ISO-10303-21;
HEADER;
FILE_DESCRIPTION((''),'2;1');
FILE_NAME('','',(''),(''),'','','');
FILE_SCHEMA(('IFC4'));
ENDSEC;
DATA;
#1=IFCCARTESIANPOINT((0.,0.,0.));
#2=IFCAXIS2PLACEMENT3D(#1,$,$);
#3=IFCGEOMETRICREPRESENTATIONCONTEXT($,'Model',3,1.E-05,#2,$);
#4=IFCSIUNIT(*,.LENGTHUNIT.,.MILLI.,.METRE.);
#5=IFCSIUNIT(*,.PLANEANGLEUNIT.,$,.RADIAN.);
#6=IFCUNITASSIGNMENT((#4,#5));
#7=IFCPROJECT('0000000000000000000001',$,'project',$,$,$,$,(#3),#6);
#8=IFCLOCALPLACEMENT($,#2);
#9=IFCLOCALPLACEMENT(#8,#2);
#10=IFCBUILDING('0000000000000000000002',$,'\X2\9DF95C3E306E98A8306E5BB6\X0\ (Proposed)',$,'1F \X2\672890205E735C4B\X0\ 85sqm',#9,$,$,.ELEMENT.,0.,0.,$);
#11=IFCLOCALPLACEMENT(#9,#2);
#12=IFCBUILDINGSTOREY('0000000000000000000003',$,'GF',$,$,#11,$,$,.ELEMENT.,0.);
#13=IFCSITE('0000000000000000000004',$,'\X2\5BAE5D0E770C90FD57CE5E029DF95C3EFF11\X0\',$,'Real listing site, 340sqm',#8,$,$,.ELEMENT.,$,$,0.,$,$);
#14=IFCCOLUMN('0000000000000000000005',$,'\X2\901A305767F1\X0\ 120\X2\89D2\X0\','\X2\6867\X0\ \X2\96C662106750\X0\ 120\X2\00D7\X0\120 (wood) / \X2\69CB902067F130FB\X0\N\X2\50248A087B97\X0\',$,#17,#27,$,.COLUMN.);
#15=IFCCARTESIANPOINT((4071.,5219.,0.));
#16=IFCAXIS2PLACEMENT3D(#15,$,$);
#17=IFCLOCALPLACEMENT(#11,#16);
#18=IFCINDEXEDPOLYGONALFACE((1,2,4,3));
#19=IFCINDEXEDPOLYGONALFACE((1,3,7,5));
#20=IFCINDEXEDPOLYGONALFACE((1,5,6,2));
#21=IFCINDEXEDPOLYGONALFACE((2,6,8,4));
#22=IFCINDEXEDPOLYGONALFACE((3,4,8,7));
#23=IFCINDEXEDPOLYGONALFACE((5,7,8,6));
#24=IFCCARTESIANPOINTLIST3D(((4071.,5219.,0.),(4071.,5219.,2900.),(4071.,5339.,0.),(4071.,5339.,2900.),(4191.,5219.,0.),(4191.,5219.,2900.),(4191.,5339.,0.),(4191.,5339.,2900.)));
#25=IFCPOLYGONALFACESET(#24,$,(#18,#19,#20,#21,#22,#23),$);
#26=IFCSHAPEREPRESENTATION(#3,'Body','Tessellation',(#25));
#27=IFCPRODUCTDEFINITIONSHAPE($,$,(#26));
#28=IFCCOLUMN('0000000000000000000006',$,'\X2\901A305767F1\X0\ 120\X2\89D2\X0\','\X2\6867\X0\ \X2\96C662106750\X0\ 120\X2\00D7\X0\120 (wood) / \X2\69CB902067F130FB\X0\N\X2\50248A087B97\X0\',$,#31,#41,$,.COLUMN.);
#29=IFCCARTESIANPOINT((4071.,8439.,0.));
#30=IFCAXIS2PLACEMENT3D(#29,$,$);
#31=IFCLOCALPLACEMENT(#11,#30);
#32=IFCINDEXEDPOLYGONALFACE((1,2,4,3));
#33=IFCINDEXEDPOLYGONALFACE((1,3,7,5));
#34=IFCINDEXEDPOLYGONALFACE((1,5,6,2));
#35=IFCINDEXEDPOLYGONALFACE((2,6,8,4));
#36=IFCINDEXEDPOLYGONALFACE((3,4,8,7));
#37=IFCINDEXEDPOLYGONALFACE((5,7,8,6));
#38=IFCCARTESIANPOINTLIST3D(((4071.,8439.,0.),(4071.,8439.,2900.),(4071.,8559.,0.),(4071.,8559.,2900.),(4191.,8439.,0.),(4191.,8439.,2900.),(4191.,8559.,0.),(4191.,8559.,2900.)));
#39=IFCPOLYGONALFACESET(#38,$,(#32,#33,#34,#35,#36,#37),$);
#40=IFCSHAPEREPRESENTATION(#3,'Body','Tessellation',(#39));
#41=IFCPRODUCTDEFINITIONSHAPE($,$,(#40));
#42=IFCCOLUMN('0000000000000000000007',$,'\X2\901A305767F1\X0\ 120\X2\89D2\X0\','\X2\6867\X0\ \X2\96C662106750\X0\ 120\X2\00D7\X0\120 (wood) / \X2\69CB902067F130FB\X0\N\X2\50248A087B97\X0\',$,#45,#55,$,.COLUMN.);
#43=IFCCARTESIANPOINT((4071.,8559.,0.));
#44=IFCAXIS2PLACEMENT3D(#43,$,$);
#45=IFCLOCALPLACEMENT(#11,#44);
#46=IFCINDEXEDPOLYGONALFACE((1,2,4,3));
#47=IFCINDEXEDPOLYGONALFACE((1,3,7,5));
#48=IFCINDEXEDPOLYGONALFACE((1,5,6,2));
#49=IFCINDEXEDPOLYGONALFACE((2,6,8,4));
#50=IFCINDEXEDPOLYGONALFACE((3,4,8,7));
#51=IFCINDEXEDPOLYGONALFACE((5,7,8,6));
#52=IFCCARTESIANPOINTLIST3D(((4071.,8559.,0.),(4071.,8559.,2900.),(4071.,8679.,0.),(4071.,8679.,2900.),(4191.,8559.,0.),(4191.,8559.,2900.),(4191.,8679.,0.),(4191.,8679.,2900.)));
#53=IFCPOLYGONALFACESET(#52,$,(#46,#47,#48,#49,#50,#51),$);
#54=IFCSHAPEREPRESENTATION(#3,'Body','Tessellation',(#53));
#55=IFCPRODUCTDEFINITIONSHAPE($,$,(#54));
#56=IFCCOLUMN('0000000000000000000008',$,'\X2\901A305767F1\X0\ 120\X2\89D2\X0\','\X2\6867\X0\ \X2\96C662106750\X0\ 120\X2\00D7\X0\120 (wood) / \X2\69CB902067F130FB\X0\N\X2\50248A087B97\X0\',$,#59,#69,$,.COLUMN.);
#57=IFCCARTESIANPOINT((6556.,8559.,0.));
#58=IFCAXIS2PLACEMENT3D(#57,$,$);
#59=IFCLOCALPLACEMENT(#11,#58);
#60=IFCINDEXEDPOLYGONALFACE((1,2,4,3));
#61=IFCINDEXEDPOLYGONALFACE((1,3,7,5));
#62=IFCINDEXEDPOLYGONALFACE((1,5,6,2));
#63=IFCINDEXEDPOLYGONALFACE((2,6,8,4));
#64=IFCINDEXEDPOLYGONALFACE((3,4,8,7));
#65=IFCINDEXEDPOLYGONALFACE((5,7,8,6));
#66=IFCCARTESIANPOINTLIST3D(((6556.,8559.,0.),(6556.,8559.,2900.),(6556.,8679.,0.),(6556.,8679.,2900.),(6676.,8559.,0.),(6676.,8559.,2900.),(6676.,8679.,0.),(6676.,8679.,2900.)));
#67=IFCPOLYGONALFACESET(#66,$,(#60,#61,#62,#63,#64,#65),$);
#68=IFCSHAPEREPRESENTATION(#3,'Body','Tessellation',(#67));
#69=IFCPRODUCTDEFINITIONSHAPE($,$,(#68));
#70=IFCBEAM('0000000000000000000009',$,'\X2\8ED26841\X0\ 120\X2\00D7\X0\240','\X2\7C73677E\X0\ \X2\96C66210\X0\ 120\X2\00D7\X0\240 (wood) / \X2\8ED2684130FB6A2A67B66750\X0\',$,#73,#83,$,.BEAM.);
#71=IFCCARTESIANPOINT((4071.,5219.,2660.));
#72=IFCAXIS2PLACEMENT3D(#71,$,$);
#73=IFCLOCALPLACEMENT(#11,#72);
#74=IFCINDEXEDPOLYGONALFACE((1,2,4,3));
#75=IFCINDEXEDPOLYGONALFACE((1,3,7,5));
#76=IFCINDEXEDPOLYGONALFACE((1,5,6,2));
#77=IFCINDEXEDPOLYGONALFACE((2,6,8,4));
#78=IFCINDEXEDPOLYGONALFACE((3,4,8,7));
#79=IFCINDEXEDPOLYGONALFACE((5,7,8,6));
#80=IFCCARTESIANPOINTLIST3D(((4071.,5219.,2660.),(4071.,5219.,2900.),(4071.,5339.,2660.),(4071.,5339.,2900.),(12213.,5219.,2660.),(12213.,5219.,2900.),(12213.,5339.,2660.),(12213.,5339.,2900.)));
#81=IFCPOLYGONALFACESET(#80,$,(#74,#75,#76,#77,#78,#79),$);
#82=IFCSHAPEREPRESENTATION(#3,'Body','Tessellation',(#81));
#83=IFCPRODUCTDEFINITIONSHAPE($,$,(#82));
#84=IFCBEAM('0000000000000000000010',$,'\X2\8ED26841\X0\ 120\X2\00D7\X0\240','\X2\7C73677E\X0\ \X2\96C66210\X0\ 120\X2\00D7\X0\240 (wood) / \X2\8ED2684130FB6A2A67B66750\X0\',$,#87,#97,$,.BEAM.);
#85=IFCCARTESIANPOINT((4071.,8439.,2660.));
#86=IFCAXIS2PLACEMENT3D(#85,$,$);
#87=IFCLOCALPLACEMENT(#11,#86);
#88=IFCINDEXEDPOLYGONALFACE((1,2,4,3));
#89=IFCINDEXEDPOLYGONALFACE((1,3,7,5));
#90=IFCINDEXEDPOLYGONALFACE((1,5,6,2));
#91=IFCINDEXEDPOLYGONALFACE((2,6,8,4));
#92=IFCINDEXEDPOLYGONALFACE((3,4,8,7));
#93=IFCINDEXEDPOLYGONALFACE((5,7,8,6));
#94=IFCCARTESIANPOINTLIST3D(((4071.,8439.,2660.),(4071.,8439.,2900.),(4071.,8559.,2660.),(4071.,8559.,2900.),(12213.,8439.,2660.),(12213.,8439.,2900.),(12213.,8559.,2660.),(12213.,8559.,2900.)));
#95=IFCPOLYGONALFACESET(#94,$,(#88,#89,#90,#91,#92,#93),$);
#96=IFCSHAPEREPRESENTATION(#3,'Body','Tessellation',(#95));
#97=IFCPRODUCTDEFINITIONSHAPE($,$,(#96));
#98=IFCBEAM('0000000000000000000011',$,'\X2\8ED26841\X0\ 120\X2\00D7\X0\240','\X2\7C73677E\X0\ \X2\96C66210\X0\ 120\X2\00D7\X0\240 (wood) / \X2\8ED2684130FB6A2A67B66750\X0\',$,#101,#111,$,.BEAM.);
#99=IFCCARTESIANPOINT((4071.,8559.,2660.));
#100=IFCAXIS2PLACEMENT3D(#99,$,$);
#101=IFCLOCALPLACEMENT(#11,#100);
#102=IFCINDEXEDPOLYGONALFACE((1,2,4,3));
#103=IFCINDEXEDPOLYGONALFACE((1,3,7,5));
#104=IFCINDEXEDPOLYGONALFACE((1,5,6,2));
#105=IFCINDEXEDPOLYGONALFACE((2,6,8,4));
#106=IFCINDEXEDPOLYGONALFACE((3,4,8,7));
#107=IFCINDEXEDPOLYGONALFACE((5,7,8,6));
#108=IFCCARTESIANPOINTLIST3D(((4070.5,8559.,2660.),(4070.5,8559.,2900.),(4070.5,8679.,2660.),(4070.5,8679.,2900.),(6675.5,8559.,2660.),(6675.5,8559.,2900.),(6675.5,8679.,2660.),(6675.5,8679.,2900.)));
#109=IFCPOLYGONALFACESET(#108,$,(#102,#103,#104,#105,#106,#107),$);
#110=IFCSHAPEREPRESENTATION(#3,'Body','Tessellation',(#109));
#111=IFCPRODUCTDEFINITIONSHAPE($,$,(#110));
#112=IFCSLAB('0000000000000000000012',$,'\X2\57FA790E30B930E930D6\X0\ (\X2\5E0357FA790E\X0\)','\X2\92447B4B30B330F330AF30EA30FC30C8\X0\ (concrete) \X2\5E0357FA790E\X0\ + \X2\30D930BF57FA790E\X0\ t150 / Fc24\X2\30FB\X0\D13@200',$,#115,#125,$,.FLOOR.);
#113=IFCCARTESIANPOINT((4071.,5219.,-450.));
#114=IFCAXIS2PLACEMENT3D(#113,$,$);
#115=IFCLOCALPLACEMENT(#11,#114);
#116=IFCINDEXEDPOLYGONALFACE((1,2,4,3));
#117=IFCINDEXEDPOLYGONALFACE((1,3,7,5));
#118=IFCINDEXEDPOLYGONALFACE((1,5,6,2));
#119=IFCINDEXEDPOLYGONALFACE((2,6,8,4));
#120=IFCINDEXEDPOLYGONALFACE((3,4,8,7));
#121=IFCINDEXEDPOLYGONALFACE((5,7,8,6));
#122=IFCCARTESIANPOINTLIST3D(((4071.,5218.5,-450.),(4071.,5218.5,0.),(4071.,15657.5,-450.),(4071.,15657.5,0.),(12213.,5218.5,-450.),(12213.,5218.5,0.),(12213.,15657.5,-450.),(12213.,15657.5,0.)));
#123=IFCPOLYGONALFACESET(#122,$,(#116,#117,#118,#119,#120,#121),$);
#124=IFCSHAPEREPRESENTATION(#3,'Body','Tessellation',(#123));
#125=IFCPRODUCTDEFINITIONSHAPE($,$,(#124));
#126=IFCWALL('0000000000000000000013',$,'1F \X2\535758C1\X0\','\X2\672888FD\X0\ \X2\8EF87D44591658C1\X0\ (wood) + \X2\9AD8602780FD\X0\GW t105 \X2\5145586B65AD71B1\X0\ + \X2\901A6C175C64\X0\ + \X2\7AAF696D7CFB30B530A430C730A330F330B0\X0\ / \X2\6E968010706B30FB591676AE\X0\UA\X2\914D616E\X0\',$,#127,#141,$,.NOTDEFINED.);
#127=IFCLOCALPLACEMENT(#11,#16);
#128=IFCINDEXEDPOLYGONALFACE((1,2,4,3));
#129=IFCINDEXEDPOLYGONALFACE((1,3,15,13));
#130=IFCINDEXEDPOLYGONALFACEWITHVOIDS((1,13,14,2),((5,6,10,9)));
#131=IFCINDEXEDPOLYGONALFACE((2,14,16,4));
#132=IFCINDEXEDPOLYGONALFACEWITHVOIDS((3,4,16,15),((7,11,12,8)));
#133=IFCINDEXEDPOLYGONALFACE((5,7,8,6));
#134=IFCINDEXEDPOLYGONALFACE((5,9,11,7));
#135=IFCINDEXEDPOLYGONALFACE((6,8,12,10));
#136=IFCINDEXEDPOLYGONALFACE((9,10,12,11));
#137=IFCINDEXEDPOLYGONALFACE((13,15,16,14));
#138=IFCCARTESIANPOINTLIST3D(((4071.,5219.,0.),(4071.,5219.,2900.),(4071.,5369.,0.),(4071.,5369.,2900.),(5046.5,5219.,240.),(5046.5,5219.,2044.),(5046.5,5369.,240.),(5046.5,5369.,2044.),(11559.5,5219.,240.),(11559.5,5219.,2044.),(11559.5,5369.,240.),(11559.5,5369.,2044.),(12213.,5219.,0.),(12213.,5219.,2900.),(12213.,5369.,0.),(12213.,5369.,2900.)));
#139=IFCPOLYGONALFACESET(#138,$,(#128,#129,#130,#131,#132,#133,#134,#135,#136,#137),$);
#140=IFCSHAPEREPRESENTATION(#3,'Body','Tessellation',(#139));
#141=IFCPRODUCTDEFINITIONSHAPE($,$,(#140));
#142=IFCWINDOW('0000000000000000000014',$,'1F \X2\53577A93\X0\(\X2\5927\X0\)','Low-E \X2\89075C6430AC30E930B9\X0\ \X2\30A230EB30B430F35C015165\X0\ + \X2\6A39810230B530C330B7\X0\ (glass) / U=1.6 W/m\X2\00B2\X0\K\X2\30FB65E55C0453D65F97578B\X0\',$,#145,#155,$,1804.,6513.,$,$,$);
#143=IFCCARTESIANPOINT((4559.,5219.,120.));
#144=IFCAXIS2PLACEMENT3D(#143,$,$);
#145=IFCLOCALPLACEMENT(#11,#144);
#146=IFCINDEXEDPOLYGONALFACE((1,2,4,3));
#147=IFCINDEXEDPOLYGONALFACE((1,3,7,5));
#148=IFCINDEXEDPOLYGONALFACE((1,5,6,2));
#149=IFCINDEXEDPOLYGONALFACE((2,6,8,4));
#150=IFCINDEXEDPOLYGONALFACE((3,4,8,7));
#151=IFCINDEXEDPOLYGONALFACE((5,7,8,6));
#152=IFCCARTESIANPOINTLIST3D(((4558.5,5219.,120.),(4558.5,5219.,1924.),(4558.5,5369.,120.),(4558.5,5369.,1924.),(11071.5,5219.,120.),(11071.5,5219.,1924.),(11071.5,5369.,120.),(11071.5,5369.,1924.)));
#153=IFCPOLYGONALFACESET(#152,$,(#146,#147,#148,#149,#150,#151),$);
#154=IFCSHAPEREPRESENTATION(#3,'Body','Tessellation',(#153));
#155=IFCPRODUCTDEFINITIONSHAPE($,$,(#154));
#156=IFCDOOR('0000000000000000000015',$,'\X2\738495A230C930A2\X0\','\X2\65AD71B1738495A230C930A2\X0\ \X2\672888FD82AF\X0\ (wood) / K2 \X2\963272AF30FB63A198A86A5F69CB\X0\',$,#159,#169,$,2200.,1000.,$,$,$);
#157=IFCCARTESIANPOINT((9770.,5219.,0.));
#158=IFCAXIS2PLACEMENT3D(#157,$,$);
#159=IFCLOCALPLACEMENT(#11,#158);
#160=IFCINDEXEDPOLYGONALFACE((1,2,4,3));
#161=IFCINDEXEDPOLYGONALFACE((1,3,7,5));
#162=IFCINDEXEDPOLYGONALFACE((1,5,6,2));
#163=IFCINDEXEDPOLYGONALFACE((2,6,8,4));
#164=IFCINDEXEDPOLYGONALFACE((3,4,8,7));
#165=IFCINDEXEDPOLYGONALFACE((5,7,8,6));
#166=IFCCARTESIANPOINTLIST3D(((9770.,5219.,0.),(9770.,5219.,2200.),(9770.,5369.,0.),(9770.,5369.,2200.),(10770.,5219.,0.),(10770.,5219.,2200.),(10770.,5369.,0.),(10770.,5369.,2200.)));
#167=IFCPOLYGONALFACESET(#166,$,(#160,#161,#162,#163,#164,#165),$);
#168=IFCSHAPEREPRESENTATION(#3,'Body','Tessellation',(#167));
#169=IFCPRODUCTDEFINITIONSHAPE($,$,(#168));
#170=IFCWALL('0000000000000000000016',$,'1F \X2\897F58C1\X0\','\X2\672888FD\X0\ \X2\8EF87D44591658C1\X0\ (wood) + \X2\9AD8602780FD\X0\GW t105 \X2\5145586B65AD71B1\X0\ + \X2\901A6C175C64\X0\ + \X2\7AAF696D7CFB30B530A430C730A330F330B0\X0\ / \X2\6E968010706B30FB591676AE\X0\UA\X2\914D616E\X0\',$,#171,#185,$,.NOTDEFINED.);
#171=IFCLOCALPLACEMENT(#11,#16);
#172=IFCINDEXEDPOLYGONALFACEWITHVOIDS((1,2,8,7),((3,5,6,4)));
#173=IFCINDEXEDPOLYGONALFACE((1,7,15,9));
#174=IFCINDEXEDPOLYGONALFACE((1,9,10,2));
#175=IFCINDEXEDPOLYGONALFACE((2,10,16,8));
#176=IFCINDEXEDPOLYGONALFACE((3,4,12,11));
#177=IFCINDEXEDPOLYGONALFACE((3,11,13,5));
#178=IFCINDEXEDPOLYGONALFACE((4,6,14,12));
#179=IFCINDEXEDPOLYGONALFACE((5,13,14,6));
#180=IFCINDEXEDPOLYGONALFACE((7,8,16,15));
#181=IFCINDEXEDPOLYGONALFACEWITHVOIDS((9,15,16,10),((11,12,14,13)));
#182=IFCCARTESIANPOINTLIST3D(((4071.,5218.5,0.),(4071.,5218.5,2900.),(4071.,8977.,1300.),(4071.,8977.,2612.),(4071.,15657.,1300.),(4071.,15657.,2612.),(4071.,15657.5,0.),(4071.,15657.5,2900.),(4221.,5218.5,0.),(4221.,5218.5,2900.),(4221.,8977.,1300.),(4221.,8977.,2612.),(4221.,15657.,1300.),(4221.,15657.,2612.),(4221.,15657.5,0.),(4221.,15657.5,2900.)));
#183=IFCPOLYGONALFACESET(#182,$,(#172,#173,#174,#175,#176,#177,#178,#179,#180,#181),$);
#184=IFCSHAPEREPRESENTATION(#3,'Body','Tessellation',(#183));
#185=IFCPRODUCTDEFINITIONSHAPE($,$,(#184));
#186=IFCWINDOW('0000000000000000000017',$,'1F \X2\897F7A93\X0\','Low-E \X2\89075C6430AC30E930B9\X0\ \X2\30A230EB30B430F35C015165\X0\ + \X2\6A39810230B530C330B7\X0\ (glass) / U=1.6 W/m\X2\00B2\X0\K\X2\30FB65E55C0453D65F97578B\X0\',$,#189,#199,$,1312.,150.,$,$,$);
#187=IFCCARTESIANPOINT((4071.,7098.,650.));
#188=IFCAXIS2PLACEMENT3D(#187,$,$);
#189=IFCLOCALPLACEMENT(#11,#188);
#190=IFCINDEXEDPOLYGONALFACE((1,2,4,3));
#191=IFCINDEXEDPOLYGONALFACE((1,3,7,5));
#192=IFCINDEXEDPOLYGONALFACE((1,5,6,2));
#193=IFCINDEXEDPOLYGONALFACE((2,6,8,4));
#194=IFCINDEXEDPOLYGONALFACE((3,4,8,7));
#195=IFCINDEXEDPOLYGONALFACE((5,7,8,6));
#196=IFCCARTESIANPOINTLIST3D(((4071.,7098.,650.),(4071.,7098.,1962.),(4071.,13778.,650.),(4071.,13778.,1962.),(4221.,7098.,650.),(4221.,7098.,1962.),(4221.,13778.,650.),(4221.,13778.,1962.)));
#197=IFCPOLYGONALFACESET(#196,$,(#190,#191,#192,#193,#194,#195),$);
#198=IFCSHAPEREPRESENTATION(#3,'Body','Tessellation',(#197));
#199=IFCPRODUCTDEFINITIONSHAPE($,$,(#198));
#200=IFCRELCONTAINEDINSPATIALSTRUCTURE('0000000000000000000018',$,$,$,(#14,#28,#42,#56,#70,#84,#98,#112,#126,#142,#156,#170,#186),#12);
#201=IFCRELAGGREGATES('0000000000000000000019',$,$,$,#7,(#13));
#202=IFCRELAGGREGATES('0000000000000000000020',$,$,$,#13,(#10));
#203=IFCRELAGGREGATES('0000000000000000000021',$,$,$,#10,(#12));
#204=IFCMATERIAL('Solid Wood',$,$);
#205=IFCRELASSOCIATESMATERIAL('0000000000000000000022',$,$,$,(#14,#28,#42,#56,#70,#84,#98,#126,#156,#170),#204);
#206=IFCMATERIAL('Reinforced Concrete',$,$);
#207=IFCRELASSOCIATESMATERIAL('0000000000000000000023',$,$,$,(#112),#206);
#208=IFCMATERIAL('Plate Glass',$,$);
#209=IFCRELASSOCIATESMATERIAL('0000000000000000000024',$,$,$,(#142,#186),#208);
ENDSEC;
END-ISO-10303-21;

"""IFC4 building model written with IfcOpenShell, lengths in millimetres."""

from ifc_helpers import new_model, si_unit, frame, frame_2d, origin, place, context, project, spatial, rectangle, extrude, material, element, fill, save


model = new_model("IFC4")

# Units and contexts
model_context = context("Model", 3, precision=1e-05, world=origin())
ifc_project = project(units=[si_unit("LENGTHUNIT", "METRE", prefix="MILLI"), si_unit("PLANEANGLEUNIT", "RADIAN")], contexts=[model_context])

# Site, building, storey
site_placement = place(None, origin())
site = spatial("IfcSite", under=ifc_project, at=site_placement, Name="宮崎県都城市鷹尾１", ObjectType="Real listing site, 340sqm", CompositionType="ELEMENT", RefElevation=0.0)
building_placement = place(site_placement, origin())
building = spatial("IfcBuilding", under=site, at=building_placement, Name="鷹尾の風の家 (Proposed)", ObjectType="1F 木造平屋 85sqm", CompositionType="ELEMENT", ElevationOfRefHeight=0.0, ElevationOfTerrain=0.0)
storey_placement = place(building_placement, origin())
storey = spatial("IfcBuildingStorey", under=building, at=storey_placement, Name="GF", CompositionType="ELEMENT", Elevation=0.0)

# Columns
ifc_material_1 = material(Name="Solid Wood")
column_1_placement = place(storey_placement, frame((4071.0, 5219.0, 0.0)))
element("IfcColumn", 1, at=column_1_placement, inside=storey, material=ifc_material_1, Name="通し柱 120角", Description="桧 集成材 120×120 (wood) / 構造柱・N値計算", PredefinedType="COLUMN", context=model_context, shape_type="SweptSolid", body=[
    extrude(rectangle(XDim=120.0, YDim=120.0, at=frame_2d((60.0, 60.0))), frame((4071.0, 5219.0, 0.0)), (0.0, 0.0, 1.0), 2900.0),
])
column_2_placement = place(storey_placement, frame((4071.0, 8439.0, 0.0)))
element("IfcColumn", 2, at=column_2_placement, inside=storey, material=ifc_material_1, Name="通し柱 120角", Description="桧 集成材 120×120 (wood) / 構造柱・N値計算", PredefinedType="COLUMN", context=model_context, shape_type="SweptSolid", body=[
    extrude(rectangle(XDim=120.0, YDim=120.0, at=frame_2d((60.0, 60.0))), frame((4071.0, 8439.0, 0.0)), (0.0, 0.0, 1.0), 2900.0),
])
column_3_placement = place(storey_placement, frame((4071.0, 8559.0, 0.0)))
element("IfcColumn", 3, at=column_3_placement, inside=storey, material=ifc_material_1, Name="通し柱 120角", Description="桧 集成材 120×120 (wood) / 構造柱・N値計算", PredefinedType="COLUMN", context=model_context, shape_type="SweptSolid", body=[
    extrude(rectangle(XDim=120.0, YDim=120.0, at=frame_2d((60.0, 60.0))), frame((4071.0, 8559.0, 0.0)), (0.0, 0.0, 1.0), 2900.0),
])
column_4_placement = place(storey_placement, frame((6556.0, 8559.0, 0.0)))
element("IfcColumn", 4, at=column_4_placement, inside=storey, material=ifc_material_1, Name="通し柱 120角", Description="桧 集成材 120×120 (wood) / 構造柱・N値計算", PredefinedType="COLUMN", context=model_context, shape_type="SweptSolid", body=[
    extrude(rectangle(XDim=120.0, YDim=120.0, at=frame_2d((60.0, 60.0))), frame((6556.0, 8559.0, 0.0)), (0.0, 0.0, 1.0), 2900.0),
])

# Beams
beam_1_placement = place(storey_placement, frame((4071.0, 5219.0, 2660.0)))
element("IfcBeam", 5, at=beam_1_placement, inside=storey, material=ifc_material_1, Name="軒桁 120×240", Description="米松 集成 120×240 (wood) / 軒桁・横架材", PredefinedType="BEAM", context=model_context, shape_type="SweptSolid", body=[
    extrude(rectangle(XDim=8142.0, YDim=120.0, at=frame_2d((4071.0, 60.0))), frame((4071.0, 5219.0, 2660.0)), (0.0, 0.0, 1.0), 240.0),
])
beam_2_placement = place(storey_placement, frame((4071.0, 8439.0, 2660.0)))
element("IfcBeam", 6, at=beam_2_placement, inside=storey, material=ifc_material_1, Name="軒桁 120×240", Description="米松 集成 120×240 (wood) / 軒桁・横架材", PredefinedType="BEAM", context=model_context, shape_type="SweptSolid", body=[
    extrude(rectangle(XDim=8142.0, YDim=120.0, at=frame_2d((4071.0, 60.0))), frame((4071.0, 8439.0, 2660.0)), (0.0, 0.0, 1.0), 240.0),
])
beam_3_placement = place(storey_placement, frame((4071.0, 8559.0, 2660.0)))
element("IfcBeam", 7, at=beam_3_placement, inside=storey, material=ifc_material_1, Name="軒桁 120×240", Description="米松 集成 120×240 (wood) / 軒桁・横架材", PredefinedType="BEAM", context=model_context, shape_type="SweptSolid", body=[
    extrude(rectangle(XDim=2605.0, YDim=120.0, at=frame_2d((1302.0, 60.0))), frame((4071.0, 8559.0, 2660.0)), (0.0, 0.0, 1.0), 240.0),
])

# Slab
ifc_material_2 = material(Name="Reinforced Concrete")
slab_1_placement = place(storey_placement, frame((4071.0, 5219.0, -450.0)))
element("IfcSlab", 8, at=slab_1_placement, inside=storey, material=ifc_material_2, Name="基礎スラブ (布基礎)", Description="鉄筋コンクリート (concrete) 布基礎 + ベタ基礎 t150 / Fc24・D13@200", PredefinedType="FLOOR", context=model_context, shape_type="SweptSolid", body=[
    extrude(rectangle(XDim=8142.0, YDim=10439.0, at=frame_2d((4071.0, 5219.0))), frame((4071.0, 5219.0, -450.0)), (0.0, 0.0, 1.0), 450.0),
])

# Wall, openings, window, door
wall_1_placement = place(storey_placement, frame((4071.0, 5219.0, 0.0)))
wall_1 = element("IfcWall", 9, at=wall_1_placement, inside=storey, material=ifc_material_1, Name="1F 南壁", Description="木製 軸組外壁 (wood) + 高性能GW t105 充填断熱 + 通気層 + 窯業系サイディング / 準耐火・外皮UA配慮", PredefinedType="NOTDEFINED", context=model_context, shape_type="SweptSolid", body=[
    extrude(rectangle(XDim=8142.0, YDim=150.0, at=frame_2d((4071.0, 75.0))), frame((4071.0, 5219.0, 0.0)), (0.0, 0.0, 1.0), 2900.0),
])
opening_1_placement = place(storey_placement, frame((4559.0, 5219.0, 120.0)))
opening_1 = element("IfcOpeningElement", 10, at=opening_1_placement, cuts=wall_1, PredefinedType="NOTDEFINED", context=model_context, shape_type="SweptSolid", body=[
    extrude(rectangle(XDim=6513.0, YDim=150.0, at=frame_2d((3256.0, 75.0))), frame((4559.0, 5219.0, 120.0)), (0.0, 0.0, 1.0), 1804.0),
])
opening_2_placement = place(storey_placement, frame((9770.0, 5219.0, 0.0)))
opening_2 = element("IfcOpeningElement", 11, at=opening_2_placement, cuts=wall_1, PredefinedType="NOTDEFINED", context=model_context, shape_type="SweptSolid", body=[
    extrude(rectangle(XDim=1000.0, YDim=150.0, at=frame_2d((500.0, 75.0))), frame((9770.0, 5219.0, 0.0)), (0.0, 0.0, 1.0), 2200.0),
])
ifc_material_3 = material(Name="Plate Glass")
window_1_placement = place(storey_placement, frame((4559.0, 5219.0, 120.0)))
window_1 = element("IfcWindow", 12, at=window_1_placement, inside=storey, material=ifc_material_3, Name="1F 南窓(大)", Description="Low-E 複層ガラス アルゴン封入 + 樹脂サッシ (glass) / U=1.6 W/m²K・日射取得型", OverallHeight=1804.0, OverallWidth=6513.0, context=model_context, shape_type="SweptSolid", body=[
    extrude(rectangle(XDim=6513.0, YDim=150.0, at=frame_2d((3256.0, 75.0))), frame((4559.0, 5219.0, 120.0)), (0.0, 0.0, 1.0), 1804.0),
])
fill(opening_1, window_1)
door_placement = place(storey_placement, frame((9770.0, 5219.0, 0.0)))
door = element("IfcDoor", 13, at=door_placement, inside=storey, material=ifc_material_1, Name="玄関ドア", Description="断熱玄関ドア 木製芯 (wood) / K2 防犯・採風機構", OverallHeight=2200.0, OverallWidth=1000.0, context=model_context, shape_type="SweptSolid", body=[
    extrude(rectangle(XDim=1000.0, YDim=150.0, at=frame_2d((500.0, 75.0))), frame((9770.0, 5219.0, 0.0)), (0.0, 0.0, 1.0), 2200.0),
])
fill(opening_2, door)

# Wall, opening, window
wall_2_placement = place(storey_placement, frame((4071.0, 5219.0, 0.0)))
wall_2 = element("IfcWall", 14, at=wall_2_placement, inside=storey, material=ifc_material_1, Name="1F 西壁", Description="木製 軸組外壁 (wood) + 高性能GW t105 充填断熱 + 通気層 + 窯業系サイディング / 準耐火・外皮UA配慮", PredefinedType="NOTDEFINED", context=model_context, shape_type="SweptSolid", body=[
    extrude(rectangle(XDim=150.0, YDim=10439.0, at=frame_2d((75.0, 5219.0))), frame((4071.0, 5219.0, 0.0)), (0.0, 0.0, 1.0), 2900.0),
])
opening_3_placement = place(storey_placement, frame((4071.0, 7098.0, 650.0)))
opening_3 = element("IfcOpeningElement", 15, at=opening_3_placement, cuts=wall_2, PredefinedType="NOTDEFINED", context=model_context, shape_type="SweptSolid", body=[
    extrude(rectangle(XDim=150.0, YDim=6680.0, at=frame_2d((75.0, 3340.0))), frame((4071.0, 7098.0, 650.0)), (0.0, 0.0, 1.0), 1312.0),
])
window_2_placement = place(storey_placement, frame((4071.0, 7098.0, 650.0)))
window_2 = element("IfcWindow", 16, at=window_2_placement, inside=storey, material=ifc_material_3, Name="1F 西窓", Description="Low-E 複層ガラス アルゴン封入 + 樹脂サッシ (glass) / U=1.6 W/m²K・日射取得型", OverallHeight=1312.0, OverallWidth=150.0, context=model_context, shape_type="SweptSolid", body=[
    extrude(rectangle(XDim=150.0, YDim=6680.0, at=frame_2d((75.0, 3340.0))), frame((4071.0, 7098.0, 650.0)), (0.0, 0.0, 1.0), 1312.0),
])
fill(opening_3, window_2)

save(model, "model.ifc")
